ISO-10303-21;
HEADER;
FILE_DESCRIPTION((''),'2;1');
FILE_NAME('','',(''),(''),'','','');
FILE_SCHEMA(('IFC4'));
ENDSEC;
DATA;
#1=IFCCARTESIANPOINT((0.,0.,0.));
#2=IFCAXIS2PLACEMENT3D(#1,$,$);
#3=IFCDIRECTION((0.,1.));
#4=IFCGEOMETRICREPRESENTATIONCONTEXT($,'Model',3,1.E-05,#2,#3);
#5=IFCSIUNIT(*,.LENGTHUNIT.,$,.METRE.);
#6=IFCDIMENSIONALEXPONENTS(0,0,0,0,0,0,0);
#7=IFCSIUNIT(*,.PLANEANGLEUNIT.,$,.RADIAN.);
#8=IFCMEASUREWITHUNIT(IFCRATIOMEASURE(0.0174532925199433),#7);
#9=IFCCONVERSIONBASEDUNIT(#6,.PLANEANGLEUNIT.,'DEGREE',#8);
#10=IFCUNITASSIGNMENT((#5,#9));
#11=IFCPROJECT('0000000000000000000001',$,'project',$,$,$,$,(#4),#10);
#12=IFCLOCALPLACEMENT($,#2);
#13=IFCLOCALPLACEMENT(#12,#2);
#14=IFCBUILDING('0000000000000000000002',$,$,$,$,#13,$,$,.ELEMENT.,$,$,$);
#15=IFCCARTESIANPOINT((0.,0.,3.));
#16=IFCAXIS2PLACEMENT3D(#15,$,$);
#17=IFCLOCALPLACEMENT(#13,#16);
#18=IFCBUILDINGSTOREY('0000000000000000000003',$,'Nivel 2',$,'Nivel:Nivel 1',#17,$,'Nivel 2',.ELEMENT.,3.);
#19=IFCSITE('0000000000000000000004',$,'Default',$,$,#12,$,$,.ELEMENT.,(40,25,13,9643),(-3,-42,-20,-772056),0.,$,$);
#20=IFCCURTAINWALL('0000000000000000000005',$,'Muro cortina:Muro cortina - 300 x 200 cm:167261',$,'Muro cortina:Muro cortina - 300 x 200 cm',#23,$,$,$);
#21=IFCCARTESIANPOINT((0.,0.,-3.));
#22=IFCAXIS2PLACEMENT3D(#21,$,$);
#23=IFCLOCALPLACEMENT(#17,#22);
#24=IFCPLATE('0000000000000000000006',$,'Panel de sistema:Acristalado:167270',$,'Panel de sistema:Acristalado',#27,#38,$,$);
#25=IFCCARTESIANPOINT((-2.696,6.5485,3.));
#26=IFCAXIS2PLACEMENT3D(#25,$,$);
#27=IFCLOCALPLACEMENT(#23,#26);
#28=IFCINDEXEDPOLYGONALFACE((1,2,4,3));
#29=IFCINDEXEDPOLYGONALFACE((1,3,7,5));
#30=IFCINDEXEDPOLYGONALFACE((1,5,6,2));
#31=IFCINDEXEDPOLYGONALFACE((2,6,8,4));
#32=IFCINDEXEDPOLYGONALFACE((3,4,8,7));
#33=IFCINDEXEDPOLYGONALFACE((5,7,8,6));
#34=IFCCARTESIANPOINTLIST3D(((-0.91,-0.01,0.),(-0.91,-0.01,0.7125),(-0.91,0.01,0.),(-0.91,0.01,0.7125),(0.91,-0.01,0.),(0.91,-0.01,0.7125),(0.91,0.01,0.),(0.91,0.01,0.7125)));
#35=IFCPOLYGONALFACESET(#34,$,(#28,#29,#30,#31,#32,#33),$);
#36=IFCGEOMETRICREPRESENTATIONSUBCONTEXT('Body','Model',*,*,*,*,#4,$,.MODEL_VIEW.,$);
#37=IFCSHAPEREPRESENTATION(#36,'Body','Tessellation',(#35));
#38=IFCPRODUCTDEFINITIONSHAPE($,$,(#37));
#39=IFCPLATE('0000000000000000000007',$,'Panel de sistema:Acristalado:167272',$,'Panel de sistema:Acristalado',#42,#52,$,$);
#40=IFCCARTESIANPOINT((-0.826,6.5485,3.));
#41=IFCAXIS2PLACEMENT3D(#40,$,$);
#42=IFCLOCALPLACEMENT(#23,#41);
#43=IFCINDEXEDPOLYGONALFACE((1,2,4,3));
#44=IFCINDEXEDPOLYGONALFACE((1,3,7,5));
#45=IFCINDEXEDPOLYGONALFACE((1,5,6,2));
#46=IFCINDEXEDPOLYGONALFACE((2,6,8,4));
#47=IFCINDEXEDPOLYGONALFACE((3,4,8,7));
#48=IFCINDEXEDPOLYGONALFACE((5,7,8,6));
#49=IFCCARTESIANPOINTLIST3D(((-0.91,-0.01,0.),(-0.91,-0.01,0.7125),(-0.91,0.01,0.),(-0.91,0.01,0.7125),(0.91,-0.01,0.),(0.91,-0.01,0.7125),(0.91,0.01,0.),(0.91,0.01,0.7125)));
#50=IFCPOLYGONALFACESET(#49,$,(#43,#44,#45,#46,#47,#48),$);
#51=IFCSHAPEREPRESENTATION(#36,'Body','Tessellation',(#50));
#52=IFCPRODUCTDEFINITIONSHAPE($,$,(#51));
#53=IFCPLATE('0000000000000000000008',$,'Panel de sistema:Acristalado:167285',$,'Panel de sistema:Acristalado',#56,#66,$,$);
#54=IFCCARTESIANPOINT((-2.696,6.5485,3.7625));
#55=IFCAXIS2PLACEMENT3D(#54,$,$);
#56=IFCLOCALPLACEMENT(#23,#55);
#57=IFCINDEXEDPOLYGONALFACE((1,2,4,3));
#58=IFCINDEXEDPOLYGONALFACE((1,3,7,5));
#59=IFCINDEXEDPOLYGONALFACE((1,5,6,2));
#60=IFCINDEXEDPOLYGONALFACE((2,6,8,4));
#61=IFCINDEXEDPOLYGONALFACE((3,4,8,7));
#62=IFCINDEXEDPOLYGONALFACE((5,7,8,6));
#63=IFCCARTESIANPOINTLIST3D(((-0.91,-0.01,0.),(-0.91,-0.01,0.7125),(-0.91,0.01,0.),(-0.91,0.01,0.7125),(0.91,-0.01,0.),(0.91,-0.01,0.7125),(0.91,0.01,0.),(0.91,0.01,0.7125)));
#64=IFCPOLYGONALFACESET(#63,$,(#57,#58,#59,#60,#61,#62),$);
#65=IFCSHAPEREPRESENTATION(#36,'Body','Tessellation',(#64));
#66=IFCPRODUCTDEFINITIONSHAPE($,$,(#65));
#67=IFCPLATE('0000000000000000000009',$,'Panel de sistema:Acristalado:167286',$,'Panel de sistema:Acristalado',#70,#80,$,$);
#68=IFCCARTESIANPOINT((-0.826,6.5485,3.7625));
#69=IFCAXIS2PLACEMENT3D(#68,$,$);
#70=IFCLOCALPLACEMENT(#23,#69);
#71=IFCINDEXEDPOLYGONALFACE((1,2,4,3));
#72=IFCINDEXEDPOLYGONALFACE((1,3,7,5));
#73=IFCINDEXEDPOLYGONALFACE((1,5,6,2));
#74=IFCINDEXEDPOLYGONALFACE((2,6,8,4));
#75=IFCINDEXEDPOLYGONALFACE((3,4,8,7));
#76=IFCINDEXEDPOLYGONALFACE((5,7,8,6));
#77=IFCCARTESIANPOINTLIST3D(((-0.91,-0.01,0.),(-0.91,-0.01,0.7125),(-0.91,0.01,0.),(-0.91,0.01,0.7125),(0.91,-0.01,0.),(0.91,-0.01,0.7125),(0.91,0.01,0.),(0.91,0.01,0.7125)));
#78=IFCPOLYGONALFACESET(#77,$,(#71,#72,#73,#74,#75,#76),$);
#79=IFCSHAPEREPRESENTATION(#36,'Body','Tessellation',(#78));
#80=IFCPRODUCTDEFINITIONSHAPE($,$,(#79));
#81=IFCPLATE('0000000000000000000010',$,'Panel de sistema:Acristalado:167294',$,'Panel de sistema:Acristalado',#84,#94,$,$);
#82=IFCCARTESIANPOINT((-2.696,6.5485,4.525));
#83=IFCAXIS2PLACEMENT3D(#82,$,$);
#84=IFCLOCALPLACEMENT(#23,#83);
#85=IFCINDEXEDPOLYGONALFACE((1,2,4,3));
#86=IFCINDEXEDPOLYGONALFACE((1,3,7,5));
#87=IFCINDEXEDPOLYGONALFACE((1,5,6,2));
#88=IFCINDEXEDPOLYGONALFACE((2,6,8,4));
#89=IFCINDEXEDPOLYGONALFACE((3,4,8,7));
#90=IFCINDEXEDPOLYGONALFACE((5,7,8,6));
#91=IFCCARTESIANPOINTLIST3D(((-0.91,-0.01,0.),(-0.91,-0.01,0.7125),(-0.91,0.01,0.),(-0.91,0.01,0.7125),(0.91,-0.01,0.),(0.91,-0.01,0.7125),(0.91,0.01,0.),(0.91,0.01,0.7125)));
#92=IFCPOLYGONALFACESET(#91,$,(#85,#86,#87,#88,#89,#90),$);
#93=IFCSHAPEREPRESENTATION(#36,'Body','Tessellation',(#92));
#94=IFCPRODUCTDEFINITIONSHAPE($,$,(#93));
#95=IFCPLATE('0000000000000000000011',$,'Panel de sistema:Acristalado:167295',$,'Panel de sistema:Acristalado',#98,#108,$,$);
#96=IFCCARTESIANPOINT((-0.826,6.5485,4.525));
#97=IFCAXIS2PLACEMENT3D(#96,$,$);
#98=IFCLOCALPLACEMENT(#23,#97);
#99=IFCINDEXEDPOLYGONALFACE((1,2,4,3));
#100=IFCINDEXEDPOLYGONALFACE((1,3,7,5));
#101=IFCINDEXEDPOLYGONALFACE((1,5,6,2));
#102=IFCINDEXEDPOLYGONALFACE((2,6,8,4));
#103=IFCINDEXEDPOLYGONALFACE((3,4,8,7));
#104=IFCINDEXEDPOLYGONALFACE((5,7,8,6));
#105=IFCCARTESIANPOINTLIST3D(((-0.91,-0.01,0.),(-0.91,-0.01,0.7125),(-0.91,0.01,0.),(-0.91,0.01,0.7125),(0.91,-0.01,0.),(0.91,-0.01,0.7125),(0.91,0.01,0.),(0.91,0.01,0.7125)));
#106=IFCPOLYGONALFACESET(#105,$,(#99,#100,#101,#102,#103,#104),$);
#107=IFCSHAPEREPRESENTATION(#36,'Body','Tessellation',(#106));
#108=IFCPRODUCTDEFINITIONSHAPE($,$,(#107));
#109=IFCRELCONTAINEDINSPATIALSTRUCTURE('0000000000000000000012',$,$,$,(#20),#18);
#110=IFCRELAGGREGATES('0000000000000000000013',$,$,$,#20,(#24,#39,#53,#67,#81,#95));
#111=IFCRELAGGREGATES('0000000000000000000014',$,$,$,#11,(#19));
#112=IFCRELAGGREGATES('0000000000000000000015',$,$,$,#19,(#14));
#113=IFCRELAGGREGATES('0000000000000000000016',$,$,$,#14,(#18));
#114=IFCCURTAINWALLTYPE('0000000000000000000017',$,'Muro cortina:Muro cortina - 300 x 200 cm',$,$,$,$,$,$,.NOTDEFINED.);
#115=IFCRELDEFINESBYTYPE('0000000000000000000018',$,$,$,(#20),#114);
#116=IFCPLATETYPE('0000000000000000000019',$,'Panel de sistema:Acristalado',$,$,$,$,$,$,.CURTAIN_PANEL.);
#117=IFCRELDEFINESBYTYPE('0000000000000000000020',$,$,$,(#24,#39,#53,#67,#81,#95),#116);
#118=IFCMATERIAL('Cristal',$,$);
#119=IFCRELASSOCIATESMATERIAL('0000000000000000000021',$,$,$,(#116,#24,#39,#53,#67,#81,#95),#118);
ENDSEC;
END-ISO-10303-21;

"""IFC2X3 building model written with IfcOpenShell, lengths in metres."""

from ifc_helpers import new_model, entity, si_unit, converted_unit, direction, frame, origin, origin_2d_with_axis, place, context, subcontext, project, spatial, rectangle, extrude, source, transform, mapped, material, type_object, type_shapes, element, aggregate, save


model = new_model("IFC2X3")

# Units and contexts
model_context = context("Model", 3, precision=1e-05, world=origin(), true_north=direction((0.0, 1.0)))
body_context = subcontext(model_context, "Body", "Model", "MODEL_VIEW")
ifc_project = project(units=[si_unit("LENGTHUNIT", "METRE"), converted_unit("PLANEANGLEUNIT", "DEGREE", entity("IfcRatioMeasure", 0.0174532925199433), si_unit("PLANEANGLEUNIT", "RADIAN"), dimensions=[0, 0, 0, 0, 0, 0, 0])], contexts=[model_context])

# Site, building, storey
site_placement = place(None, origin())
site = spatial("IfcSite", under=ifc_project, at=site_placement, Name="Default", CompositionType="ELEMENT", RefLatitude=(40, 25, 13, 9643), RefLongitude=(-3, -42, -20, -772056), RefElevation=0.0)
building_placement = place(site_placement, origin())
building = spatial("IfcBuilding", under=site, at=building_placement, CompositionType="ELEMENT")
storey_placement = place(building_placement, frame((0.0, 0.0, 3.0)))
storey = spatial("IfcBuildingStorey", under=building, at=storey_placement, Name="Nivel 2", ObjectType="Nivel:Nivel 1", LongName="Nivel 2", CompositionType="ELEMENT", Elevation=3.0)

# Curtain wall
curtain_wall_type = type_object("IfcCurtainWallType", Name="Muro cortina:Muro cortina - 300 x 200 cm", PredefinedType="NOTDEFINED")
curtain_wall_1_placement = place(storey_placement, frame((0.0, 0.0, -3.0)))
curtain_wall_1 = element("IfcCurtainWall", 1, at=curtain_wall_1_placement, inside=storey, type_object=curtain_wall_type, Name="Muro cortina:Muro cortina - 300 x 200 cm:167261", ObjectType="Muro cortina:Muro cortina - 300 x 200 cm")

# Plates
ifc_material_1 = material(Name="Cristal")
plate_type = type_object("IfcPlateType", Name="Panel de sistema:Acristalado", PredefinedType="CURTAIN_PANEL", material=ifc_material_1)
shared_shape_1 = source(origin(), body_context, "Body", "SweptSolid", [
    extrude(rectangle(XDim=0.02, YDim=1.82, at=origin_2d_with_axis()), frame((0.0, 0.0, 0.0), z_axis=(0.0, 0.0, 1.0), x_axis=(0.0, 1.0, 0.0)), (0.0, 0.0, 1.0), 0.7125),
])
type_shapes(plate_type, [shared_shape_1])
plate_1_placement = place(curtain_wall_1_placement, frame((-2.696, 6.5485, 3.0)))
plate_1 = element("IfcPlate", 2, at=plate_1_placement, type_object=plate_type, material=ifc_material_1, Name="Panel de sistema:Acristalado:167270", ObjectType="Panel de sistema:Acristalado", context=body_context, shape_type="MappedRepresentation", body=[
    mapped(shared_shape_1, transform((0.0, 0.0, 0.0), scale=1.0)),
])
plate_2_placement = place(curtain_wall_1_placement, frame((-0.826, 6.5485, 3.0)))
plate_2 = element("IfcPlate", 3, at=plate_2_placement, type_object=plate_type, material=ifc_material_1, Name="Panel de sistema:Acristalado:167272", ObjectType="Panel de sistema:Acristalado", context=body_context, shape_type="MappedRepresentation", body=[
    mapped(shared_shape_1, transform((0.0, 0.0, 0.0), scale=1.0)),
])
plate_3_placement = place(curtain_wall_1_placement, frame((-2.696, 6.5485, 3.7625)))
plate_3 = element("IfcPlate", 4, at=plate_3_placement, type_object=plate_type, material=ifc_material_1, Name="Panel de sistema:Acristalado:167285", ObjectType="Panel de sistema:Acristalado", context=body_context, shape_type="MappedRepresentation", body=[
    mapped(shared_shape_1, transform((0.0, 0.0, 0.0), scale=1.0)),
])
plate_4_placement = place(curtain_wall_1_placement, frame((-0.826, 6.5485, 3.7625)))
plate_4 = element("IfcPlate", 5, at=plate_4_placement, type_object=plate_type, material=ifc_material_1, Name="Panel de sistema:Acristalado:167286", ObjectType="Panel de sistema:Acristalado", context=body_context, shape_type="MappedRepresentation", body=[
    mapped(shared_shape_1, transform((0.0, 0.0, 0.0), scale=1.0)),
])
plate_5_placement = place(curtain_wall_1_placement, frame((-2.696, 6.5485, 4.525)))
plate_5 = element("IfcPlate", 6, at=plate_5_placement, type_object=plate_type, material=ifc_material_1, Name="Panel de sistema:Acristalado:167294", ObjectType="Panel de sistema:Acristalado", context=body_context, shape_type="MappedRepresentation", body=[
    mapped(shared_shape_1, transform((0.0, 0.0, 0.0), scale=1.0)),
])
plate_6_placement = place(curtain_wall_1_placement, frame((-0.826, 6.5485, 4.525)))
plate_6 = element("IfcPlate", 7, at=plate_6_placement, type_object=plate_type, material=ifc_material_1, Name="Panel de sistema:Acristalado:167295", ObjectType="Panel de sistema:Acristalado", context=body_context, shape_type="MappedRepresentation", body=[
    mapped(shared_shape_1, transform((0.0, 0.0, 0.0), scale=1.0)),
])
aggregate(curtain_wall_1, [plate_1, plate_2, plate_3, plate_4, plate_5, plate_6])

save(model, "model.ifc")
